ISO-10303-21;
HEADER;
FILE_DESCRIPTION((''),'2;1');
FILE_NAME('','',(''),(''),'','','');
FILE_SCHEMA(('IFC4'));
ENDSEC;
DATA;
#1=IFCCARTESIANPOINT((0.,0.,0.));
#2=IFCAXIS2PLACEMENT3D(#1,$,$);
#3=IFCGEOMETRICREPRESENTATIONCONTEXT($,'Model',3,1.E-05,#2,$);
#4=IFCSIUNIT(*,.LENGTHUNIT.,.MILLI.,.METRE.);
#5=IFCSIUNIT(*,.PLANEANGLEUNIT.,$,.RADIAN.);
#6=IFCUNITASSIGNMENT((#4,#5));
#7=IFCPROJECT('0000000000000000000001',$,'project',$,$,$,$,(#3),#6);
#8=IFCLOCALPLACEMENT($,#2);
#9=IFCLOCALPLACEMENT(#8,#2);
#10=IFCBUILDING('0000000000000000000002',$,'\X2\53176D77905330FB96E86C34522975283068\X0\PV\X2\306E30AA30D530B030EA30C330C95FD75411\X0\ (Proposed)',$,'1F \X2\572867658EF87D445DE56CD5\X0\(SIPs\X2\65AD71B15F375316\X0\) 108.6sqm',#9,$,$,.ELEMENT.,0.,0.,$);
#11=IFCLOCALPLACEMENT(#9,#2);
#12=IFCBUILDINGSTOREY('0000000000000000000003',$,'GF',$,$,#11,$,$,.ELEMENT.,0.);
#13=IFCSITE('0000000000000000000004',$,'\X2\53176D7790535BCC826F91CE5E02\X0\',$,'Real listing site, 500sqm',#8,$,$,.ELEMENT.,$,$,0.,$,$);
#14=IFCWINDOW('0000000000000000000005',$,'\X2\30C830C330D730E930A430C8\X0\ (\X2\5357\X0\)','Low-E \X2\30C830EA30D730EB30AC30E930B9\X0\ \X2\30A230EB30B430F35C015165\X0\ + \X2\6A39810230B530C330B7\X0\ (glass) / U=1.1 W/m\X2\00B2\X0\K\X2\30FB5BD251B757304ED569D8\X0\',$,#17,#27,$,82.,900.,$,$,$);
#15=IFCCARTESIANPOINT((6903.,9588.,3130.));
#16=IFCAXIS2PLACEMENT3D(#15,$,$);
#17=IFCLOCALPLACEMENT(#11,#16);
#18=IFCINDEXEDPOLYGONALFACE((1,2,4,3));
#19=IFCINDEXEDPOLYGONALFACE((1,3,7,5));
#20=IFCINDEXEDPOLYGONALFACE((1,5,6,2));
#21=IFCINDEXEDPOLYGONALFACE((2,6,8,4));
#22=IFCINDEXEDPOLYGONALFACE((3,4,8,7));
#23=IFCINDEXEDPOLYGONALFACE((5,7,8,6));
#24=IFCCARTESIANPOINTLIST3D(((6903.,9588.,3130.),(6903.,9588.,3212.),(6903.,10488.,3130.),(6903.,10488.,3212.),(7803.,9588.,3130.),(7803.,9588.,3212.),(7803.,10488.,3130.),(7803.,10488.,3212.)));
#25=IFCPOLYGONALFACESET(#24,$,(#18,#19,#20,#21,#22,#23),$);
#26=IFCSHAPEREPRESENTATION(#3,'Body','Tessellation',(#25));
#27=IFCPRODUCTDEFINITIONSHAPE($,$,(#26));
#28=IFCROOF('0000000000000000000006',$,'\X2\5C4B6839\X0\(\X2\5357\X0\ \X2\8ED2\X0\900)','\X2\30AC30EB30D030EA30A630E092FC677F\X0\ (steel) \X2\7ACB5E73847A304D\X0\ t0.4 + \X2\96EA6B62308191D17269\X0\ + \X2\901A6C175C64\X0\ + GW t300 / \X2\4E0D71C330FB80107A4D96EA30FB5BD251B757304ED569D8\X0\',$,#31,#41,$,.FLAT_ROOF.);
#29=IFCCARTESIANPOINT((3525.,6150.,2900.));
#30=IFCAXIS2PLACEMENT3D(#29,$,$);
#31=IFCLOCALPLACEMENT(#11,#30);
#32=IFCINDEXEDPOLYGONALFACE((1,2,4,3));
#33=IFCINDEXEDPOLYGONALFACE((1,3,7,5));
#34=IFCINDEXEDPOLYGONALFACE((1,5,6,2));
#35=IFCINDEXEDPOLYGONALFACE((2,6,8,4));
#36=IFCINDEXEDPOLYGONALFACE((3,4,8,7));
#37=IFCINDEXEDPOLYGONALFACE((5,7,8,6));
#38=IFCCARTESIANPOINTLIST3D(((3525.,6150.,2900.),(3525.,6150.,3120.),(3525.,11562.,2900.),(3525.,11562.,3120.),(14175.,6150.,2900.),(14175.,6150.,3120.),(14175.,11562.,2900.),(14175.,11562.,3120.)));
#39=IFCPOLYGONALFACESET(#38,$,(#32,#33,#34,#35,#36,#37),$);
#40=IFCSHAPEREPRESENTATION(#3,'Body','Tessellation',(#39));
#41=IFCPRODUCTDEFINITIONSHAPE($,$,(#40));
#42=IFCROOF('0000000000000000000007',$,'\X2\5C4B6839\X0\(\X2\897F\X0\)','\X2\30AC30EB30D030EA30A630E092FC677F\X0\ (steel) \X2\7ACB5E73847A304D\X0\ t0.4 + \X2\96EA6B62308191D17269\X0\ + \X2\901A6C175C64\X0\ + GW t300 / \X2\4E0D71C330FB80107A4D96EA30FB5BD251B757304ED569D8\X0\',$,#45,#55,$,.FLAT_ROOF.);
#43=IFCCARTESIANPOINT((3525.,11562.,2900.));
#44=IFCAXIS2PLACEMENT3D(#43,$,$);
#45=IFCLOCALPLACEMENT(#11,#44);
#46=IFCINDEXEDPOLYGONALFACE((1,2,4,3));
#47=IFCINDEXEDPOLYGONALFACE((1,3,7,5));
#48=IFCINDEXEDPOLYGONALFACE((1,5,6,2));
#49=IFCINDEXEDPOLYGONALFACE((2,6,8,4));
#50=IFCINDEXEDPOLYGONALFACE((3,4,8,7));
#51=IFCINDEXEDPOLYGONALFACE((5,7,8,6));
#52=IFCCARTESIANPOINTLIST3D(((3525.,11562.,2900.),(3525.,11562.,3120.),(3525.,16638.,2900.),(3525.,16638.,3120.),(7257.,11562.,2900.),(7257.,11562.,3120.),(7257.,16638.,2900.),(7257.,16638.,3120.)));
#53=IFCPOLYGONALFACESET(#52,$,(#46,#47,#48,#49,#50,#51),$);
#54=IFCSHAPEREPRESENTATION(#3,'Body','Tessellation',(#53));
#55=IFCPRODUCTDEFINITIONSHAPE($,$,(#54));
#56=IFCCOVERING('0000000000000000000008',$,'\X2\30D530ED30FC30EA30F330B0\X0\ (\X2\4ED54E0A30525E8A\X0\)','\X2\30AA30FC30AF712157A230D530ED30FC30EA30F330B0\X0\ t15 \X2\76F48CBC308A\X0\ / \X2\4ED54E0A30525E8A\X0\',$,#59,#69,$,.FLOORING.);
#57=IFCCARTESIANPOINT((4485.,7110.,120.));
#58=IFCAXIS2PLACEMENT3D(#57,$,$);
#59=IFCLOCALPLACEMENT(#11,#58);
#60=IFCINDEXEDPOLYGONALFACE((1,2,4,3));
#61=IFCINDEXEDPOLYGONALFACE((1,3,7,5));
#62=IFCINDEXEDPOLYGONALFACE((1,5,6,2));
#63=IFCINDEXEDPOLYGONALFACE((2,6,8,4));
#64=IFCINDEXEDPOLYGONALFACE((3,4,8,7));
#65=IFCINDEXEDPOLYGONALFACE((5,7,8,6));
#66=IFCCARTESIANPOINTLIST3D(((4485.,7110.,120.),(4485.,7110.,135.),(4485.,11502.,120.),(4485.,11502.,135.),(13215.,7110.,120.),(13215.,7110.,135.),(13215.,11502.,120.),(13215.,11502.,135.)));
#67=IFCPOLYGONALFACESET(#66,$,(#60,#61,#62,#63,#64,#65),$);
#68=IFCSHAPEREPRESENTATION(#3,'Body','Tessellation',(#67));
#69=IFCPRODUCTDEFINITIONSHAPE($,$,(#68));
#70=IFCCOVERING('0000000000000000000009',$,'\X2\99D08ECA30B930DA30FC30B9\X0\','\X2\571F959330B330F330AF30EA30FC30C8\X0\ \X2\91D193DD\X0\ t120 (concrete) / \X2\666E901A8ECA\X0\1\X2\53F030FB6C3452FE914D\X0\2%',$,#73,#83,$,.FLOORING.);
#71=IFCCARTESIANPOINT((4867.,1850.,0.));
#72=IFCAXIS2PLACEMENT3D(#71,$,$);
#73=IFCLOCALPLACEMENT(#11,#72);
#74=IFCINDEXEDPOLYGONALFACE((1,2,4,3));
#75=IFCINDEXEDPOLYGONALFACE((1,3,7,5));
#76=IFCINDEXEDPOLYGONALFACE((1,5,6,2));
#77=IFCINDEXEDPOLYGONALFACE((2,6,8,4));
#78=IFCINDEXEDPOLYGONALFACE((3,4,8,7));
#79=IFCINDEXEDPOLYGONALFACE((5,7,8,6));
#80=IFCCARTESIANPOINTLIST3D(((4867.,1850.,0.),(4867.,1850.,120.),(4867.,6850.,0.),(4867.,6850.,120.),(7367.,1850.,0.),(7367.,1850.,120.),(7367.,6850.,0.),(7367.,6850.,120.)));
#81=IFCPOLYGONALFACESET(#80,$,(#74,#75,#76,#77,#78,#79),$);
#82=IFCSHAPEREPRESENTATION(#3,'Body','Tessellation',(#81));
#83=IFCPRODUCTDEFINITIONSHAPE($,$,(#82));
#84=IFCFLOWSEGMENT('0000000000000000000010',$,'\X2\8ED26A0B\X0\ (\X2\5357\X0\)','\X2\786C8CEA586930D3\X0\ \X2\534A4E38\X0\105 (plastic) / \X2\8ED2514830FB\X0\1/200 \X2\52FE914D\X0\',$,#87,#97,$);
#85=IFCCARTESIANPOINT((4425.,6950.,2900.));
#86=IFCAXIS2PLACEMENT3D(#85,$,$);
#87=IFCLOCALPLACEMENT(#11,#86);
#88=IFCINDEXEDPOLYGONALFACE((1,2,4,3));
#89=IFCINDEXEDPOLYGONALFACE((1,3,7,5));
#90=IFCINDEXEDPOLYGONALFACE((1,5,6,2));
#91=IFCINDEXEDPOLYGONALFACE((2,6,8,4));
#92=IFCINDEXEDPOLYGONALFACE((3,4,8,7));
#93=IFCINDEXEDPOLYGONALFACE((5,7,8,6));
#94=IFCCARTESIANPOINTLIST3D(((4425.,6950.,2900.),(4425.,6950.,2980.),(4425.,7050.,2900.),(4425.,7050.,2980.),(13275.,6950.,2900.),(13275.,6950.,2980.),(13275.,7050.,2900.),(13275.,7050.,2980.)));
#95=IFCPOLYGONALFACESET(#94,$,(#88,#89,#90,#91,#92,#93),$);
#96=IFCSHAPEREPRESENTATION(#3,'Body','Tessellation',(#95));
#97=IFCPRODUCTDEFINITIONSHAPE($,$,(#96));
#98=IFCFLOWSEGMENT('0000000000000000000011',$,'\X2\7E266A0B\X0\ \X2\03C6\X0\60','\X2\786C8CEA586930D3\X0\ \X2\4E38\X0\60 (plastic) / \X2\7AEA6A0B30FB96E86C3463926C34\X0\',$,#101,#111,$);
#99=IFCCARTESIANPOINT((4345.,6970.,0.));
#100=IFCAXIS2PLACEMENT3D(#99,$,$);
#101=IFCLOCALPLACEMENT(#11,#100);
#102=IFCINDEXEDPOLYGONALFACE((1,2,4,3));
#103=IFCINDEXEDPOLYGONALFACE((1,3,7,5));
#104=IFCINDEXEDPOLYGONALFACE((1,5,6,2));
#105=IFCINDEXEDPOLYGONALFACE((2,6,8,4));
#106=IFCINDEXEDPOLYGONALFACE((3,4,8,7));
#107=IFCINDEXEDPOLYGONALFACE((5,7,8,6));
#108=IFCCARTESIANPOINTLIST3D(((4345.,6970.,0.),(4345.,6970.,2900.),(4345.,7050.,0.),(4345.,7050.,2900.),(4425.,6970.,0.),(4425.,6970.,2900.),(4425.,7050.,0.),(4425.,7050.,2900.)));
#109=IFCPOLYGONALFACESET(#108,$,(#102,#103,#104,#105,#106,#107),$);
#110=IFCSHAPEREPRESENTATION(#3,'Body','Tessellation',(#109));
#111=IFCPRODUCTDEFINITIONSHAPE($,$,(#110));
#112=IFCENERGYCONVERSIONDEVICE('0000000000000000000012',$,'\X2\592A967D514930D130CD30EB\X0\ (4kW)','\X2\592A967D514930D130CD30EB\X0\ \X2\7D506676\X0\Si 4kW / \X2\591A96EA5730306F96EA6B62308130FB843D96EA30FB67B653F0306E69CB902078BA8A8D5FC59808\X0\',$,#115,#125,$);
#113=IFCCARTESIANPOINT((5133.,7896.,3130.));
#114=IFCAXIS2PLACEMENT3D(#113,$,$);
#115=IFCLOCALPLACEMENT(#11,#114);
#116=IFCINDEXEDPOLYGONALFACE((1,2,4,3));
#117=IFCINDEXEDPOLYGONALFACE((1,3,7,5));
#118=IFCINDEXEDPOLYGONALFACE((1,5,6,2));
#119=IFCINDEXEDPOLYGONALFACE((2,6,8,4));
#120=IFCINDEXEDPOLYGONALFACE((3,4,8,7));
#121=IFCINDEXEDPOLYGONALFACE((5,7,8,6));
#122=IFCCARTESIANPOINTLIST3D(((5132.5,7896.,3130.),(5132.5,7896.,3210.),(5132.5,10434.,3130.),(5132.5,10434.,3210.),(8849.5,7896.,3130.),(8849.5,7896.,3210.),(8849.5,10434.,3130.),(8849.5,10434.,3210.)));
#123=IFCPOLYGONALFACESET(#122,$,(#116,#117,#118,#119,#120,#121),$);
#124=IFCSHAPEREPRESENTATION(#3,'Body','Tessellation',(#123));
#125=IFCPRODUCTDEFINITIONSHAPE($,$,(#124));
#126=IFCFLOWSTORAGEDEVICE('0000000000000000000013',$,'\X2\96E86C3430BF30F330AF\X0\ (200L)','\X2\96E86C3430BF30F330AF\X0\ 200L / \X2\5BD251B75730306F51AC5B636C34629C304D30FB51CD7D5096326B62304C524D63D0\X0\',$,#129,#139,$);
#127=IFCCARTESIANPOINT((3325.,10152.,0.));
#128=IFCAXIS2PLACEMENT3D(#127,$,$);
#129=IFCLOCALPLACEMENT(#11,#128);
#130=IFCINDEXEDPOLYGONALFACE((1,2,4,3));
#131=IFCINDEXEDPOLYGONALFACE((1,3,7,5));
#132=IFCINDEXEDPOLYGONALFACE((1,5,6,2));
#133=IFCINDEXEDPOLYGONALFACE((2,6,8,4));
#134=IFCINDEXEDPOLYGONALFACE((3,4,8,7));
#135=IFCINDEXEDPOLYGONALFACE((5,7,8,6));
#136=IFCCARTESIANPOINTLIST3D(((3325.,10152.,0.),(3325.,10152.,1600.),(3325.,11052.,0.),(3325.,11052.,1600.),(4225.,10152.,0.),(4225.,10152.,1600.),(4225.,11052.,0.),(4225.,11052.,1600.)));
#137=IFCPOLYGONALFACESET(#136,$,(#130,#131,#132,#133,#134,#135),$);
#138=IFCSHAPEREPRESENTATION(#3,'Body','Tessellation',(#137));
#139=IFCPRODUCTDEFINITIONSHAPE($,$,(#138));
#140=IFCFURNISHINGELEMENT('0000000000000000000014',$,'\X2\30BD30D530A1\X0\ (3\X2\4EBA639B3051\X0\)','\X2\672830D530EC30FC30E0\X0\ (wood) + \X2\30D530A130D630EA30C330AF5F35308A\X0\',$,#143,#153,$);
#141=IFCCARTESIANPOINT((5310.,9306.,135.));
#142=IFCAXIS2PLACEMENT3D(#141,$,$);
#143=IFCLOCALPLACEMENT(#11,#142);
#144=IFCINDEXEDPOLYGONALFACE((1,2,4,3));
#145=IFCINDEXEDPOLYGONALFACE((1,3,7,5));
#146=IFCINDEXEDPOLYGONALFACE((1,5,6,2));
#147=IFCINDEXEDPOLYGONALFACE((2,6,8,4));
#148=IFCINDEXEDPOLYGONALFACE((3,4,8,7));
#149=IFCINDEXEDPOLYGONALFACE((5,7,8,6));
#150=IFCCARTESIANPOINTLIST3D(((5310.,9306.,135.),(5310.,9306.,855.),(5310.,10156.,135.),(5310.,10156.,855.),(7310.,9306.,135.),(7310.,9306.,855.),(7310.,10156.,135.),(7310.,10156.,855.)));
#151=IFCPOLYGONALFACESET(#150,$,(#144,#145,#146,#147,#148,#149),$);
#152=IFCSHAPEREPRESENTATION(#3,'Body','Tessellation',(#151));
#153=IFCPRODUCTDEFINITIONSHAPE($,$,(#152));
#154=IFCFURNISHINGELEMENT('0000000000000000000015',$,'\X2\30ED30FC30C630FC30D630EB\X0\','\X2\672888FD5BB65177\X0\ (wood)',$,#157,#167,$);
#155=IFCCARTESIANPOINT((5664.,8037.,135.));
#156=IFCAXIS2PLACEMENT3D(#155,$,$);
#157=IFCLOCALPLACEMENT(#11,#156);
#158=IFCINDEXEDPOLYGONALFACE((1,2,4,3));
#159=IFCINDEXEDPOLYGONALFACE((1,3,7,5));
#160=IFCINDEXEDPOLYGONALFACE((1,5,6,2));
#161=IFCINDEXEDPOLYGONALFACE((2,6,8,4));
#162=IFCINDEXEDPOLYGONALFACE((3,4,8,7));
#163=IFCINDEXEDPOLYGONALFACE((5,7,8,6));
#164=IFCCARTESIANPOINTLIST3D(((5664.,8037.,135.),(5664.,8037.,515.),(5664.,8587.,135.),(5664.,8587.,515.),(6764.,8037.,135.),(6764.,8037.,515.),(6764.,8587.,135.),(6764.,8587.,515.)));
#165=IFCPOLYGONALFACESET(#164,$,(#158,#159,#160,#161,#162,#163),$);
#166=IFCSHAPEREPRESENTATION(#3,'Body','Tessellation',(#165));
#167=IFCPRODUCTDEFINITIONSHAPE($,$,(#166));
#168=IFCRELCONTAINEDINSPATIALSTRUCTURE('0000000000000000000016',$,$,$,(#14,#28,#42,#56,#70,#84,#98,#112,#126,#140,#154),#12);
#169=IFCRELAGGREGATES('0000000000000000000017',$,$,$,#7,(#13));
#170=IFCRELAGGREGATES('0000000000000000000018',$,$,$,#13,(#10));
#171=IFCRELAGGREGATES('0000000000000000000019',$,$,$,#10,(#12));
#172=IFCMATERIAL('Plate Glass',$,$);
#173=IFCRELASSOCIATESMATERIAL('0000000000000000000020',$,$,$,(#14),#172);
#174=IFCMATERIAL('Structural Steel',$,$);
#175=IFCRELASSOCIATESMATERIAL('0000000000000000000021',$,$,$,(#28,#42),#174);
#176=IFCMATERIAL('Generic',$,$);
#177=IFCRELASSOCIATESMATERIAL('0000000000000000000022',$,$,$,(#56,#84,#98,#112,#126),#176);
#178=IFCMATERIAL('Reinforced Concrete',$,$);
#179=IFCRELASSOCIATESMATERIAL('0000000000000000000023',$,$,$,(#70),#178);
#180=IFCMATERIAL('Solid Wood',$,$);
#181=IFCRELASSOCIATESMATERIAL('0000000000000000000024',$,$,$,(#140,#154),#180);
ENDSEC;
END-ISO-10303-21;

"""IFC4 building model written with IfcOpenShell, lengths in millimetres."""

from ifc_helpers import new_model, si_unit, frame, frame_2d, origin, place, context, project, spatial, rectangle, extrude, material, element, save


model = new_model("IFC4")

# Units and contexts
model_context = context("Model", 3, precision=1e-05, world=origin())
ifc_project = project(units=[si_unit("LENGTHUNIT", "METRE", prefix="MILLI"), si_unit("PLANEANGLEUNIT", "RADIAN")], contexts=[model_context])

# Site, building, storey
site_placement = place(None, origin())
site = spatial("IfcSite", under=ifc_project, at=site_placement, Name="北海道富良野市", ObjectType="Real listing site, 500sqm", CompositionType="ELEMENT", RefElevation=0.0)
building_placement = place(site_placement, origin())
building = spatial("IfcBuilding", under=site, at=building_placement, Name="北海道・雨水利用とPVのオフグリッド志向 (Proposed)", ObjectType="1F 在来軸組工法(SIPs断熱強化) 108.6sqm", CompositionType="ELEMENT", ElevationOfRefHeight=0.0, ElevationOfTerrain=0.0)
storey_placement = place(building_placement, origin())
storey = spatial("IfcBuildingStorey", under=building, at=storey_placement, Name="GF", CompositionType="ELEMENT", Elevation=0.0)

# Shared definitions
ifc_material_1 = material(Name="Solid Wood")

# Shared definitions
ifc_material_2 = material(Name="Reinforced Concrete")

# Shared definitions
ifc_material_3 = material(Name="Plate Glass")

# Window
window_1_placement = place(storey_placement, frame((6903.0, 9588.0, 3130.0)))
element("IfcWindow", 1, at=window_1_placement, inside=storey, material=ifc_material_3, Name="トップライト (南)", Description="Low-E トリプルガラス アルゴン封入 + 樹脂サッシ (glass) / U=1.1 W/m²K・寒冷地仕様", OverallHeight=82.0, OverallWidth=900.0, context=model_context, shape_type="SweptSolid", body=[
    extrude(rectangle(XDim=900.0, YDim=900.0, at=frame_2d((450.0, 450.0))), frame((6903.0, 9588.0, 3130.0)), (0.0, 0.0, 1.0), 82.0),
])

# Roofs
ifc_material_4 = material(Name="Structural Steel")
roof_1_placement = place(storey_placement, frame((3525.0, 6150.0, 2900.0)))
element("IfcRoof", 2, at=roof_1_placement, inside=storey, material=ifc_material_4, Name="屋根(南 軒900)", Description="ガルバリウム鋼板 (steel) 立平葺き t0.4 + 雪止め金物 + 通気層 + GW t300 / 不燃・耐積雪・寒冷地仕様", PredefinedType="FLAT_ROOF", context=model_context, shape_type="SweptSolid", body=[
    extrude(rectangle(XDim=10650.0, YDim=5412.0, at=frame_2d((5325.0, 2706.0))), frame((3525.0, 6150.0, 2900.0)), (0.0, 0.0, 1.0), 220.0),
])
roof_2_placement = place(storey_placement, frame((3525.0, 11562.0, 2900.0)))
element("IfcRoof", 3, at=roof_2_placement, inside=storey, material=ifc_material_4, Name="屋根(西)", Description="ガルバリウム鋼板 (steel) 立平葺き t0.4 + 雪止め金物 + 通気層 + GW t300 / 不燃・耐積雪・寒冷地仕様", PredefinedType="FLAT_ROOF", context=model_context, shape_type="SweptSolid", body=[
    extrude(rectangle(XDim=3732.0, YDim=5076.0, at=frame_2d((1866.0, 2538.0))), frame((3525.0, 11562.0, 2900.0)), (0.0, 0.0, 1.0), 220.0),
])

# Coverings
ifc_material_5 = material(Name="Generic")
covering_1_placement = place(storey_placement, frame((4485.0, 7110.0, 120.0)))
element("IfcCovering", 4, at=covering_1_placement, inside=storey, material=ifc_material_5, Name="フローリング (仕上げ床)", Description="オーク無垢フローリング t15 直貼り / 仕上げ床", PredefinedType="FLOORING", context=model_context, shape_type="SweptSolid", body=[
    extrude(rectangle(XDim=8730.0, YDim=4392.0, at=frame_2d((4365.0, 2196.0))), frame((4485.0, 7110.0, 120.0)), (0.0, 0.0, 1.0), 15.0),
])
covering_2_placement = place(storey_placement, frame((4867.0, 1850.0, 0.0)))
element("IfcCovering", 5, at=covering_2_placement, inside=storey, material=ifc_material_2, Name="駐車スペース", Description="土間コンクリート 金鏝 t120 (concrete) / 普通車1台・水勾配2%", PredefinedType="FLOORING", context=model_context, shape_type="SweptSolid", body=[
    extrude(rectangle(XDim=2500.0, YDim=5000.0, at=frame_2d((1250.0, 2500.0))), frame((4867.0, 1850.0, 0.0)), (0.0, 0.0, 1.0), 120.0),
])

# Flow segments
flow_segment_1_placement = place(storey_placement, frame((4425.0, 6950.0, 2900.0)))
element("IfcFlowSegment", 6, at=flow_segment_1_placement, inside=storey, material=ifc_material_5, Name="軒樋 (南)", Description="硬質塩ビ 半丸105 (plastic) / 軒先・1/200 勾配", context=model_context, shape_type="SweptSolid", body=[
    extrude(rectangle(XDim=8850.0, YDim=100.0, at=frame_2d((4425.0, 50.0))), frame((4425.0, 6950.0, 2900.0)), (0.0, 0.0, 1.0), 80.0),
])
flow_segment_2_placement = place(storey_placement, frame((4345.0, 6970.0, 0.0)))
element("IfcFlowSegment", 7, at=flow_segment_2_placement, inside=storey, material=ifc_material_5, Name="縦樋 φ60", Description="硬質塩ビ 丸60 (plastic) / 竪樋・雨水排水", context=model_context, shape_type="SweptSolid", body=[
    extrude(rectangle(XDim=80.0, YDim=80.0, at=frame_2d((40.0, 40.0))), frame((4345.0, 6970.0, 0.0)), (0.0, 0.0, 1.0), 2900.0),
])

# Energy conversion device
energy_conversion_device_placement = place(storey_placement, frame((5133.0, 7896.0, 3130.0)))
element("IfcEnergyConversionDevice", 8, at=energy_conversion_device_placement, inside=storey, material=ifc_material_5, Name="太陽光パネル (4kW)", Description="太陽光パネル 結晶Si 4kW / 多雪地は雪止め・落雪・架台の構造確認必須", context=model_context, shape_type="SweptSolid", body=[
    extrude(rectangle(XDim=3717.0, YDim=2538.0, at=frame_2d((1858.0, 1269.0))), frame((5133.0, 7896.0, 3130.0)), (0.0, 0.0, 1.0), 80.0),
])

# Flow storage device
flow_storage_device_placement = place(storey_placement, frame((3325.0, 10152.0, 0.0)))
element("IfcFlowStorageDevice", 9, at=flow_storage_device_placement, inside=storey, material=ifc_material_5, Name="雨水タンク (200L)", Description="雨水タンク 200L / 寒冷地は冬季水抜き・凍結防止が前提", context=model_context, shape_type="SweptSolid", body=[
    extrude(rectangle(XDim=900.0, YDim=900.0, at=frame_2d((450.0, 450.0))), frame((3325.0, 10152.0, 0.0)), (0.0, 0.0, 1.0), 1600.0),
])

# Furnishing elements
furnishing_1_placement = place(storey_placement, frame((5310.0, 9306.0, 135.0)))
element("IfcFurnishingElement", 10, at=furnishing_1_placement, inside=storey, material=ifc_material_1, Name="ソファ (3人掛け)", Description="木フレーム (wood) + ファブリック張り", context=model_context, shape_type="SweptSolid", body=[
    extrude(rectangle(XDim=2000.0, YDim=850.0, at=frame_2d((1000.0, 425.0))), frame((5310.0, 9306.0, 135.0)), (0.0, 0.0, 1.0), 720.0),
])
furnishing_2_placement = place(storey_placement, frame((5664.0, 8037.0, 135.0)))
element("IfcFurnishingElement", 11, at=furnishing_2_placement, inside=storey, material=ifc_material_1, Name="ローテーブル", Description="木製家具 (wood)", context=model_context, shape_type="SweptSolid", body=[
    extrude(rectangle(XDim=1100.0, YDim=550.0, at=frame_2d((550.0, 275.0))), frame((5664.0, 8037.0, 135.0)), (0.0, 0.0, 1.0), 380.0),
])

save(model, "model.ifc")
